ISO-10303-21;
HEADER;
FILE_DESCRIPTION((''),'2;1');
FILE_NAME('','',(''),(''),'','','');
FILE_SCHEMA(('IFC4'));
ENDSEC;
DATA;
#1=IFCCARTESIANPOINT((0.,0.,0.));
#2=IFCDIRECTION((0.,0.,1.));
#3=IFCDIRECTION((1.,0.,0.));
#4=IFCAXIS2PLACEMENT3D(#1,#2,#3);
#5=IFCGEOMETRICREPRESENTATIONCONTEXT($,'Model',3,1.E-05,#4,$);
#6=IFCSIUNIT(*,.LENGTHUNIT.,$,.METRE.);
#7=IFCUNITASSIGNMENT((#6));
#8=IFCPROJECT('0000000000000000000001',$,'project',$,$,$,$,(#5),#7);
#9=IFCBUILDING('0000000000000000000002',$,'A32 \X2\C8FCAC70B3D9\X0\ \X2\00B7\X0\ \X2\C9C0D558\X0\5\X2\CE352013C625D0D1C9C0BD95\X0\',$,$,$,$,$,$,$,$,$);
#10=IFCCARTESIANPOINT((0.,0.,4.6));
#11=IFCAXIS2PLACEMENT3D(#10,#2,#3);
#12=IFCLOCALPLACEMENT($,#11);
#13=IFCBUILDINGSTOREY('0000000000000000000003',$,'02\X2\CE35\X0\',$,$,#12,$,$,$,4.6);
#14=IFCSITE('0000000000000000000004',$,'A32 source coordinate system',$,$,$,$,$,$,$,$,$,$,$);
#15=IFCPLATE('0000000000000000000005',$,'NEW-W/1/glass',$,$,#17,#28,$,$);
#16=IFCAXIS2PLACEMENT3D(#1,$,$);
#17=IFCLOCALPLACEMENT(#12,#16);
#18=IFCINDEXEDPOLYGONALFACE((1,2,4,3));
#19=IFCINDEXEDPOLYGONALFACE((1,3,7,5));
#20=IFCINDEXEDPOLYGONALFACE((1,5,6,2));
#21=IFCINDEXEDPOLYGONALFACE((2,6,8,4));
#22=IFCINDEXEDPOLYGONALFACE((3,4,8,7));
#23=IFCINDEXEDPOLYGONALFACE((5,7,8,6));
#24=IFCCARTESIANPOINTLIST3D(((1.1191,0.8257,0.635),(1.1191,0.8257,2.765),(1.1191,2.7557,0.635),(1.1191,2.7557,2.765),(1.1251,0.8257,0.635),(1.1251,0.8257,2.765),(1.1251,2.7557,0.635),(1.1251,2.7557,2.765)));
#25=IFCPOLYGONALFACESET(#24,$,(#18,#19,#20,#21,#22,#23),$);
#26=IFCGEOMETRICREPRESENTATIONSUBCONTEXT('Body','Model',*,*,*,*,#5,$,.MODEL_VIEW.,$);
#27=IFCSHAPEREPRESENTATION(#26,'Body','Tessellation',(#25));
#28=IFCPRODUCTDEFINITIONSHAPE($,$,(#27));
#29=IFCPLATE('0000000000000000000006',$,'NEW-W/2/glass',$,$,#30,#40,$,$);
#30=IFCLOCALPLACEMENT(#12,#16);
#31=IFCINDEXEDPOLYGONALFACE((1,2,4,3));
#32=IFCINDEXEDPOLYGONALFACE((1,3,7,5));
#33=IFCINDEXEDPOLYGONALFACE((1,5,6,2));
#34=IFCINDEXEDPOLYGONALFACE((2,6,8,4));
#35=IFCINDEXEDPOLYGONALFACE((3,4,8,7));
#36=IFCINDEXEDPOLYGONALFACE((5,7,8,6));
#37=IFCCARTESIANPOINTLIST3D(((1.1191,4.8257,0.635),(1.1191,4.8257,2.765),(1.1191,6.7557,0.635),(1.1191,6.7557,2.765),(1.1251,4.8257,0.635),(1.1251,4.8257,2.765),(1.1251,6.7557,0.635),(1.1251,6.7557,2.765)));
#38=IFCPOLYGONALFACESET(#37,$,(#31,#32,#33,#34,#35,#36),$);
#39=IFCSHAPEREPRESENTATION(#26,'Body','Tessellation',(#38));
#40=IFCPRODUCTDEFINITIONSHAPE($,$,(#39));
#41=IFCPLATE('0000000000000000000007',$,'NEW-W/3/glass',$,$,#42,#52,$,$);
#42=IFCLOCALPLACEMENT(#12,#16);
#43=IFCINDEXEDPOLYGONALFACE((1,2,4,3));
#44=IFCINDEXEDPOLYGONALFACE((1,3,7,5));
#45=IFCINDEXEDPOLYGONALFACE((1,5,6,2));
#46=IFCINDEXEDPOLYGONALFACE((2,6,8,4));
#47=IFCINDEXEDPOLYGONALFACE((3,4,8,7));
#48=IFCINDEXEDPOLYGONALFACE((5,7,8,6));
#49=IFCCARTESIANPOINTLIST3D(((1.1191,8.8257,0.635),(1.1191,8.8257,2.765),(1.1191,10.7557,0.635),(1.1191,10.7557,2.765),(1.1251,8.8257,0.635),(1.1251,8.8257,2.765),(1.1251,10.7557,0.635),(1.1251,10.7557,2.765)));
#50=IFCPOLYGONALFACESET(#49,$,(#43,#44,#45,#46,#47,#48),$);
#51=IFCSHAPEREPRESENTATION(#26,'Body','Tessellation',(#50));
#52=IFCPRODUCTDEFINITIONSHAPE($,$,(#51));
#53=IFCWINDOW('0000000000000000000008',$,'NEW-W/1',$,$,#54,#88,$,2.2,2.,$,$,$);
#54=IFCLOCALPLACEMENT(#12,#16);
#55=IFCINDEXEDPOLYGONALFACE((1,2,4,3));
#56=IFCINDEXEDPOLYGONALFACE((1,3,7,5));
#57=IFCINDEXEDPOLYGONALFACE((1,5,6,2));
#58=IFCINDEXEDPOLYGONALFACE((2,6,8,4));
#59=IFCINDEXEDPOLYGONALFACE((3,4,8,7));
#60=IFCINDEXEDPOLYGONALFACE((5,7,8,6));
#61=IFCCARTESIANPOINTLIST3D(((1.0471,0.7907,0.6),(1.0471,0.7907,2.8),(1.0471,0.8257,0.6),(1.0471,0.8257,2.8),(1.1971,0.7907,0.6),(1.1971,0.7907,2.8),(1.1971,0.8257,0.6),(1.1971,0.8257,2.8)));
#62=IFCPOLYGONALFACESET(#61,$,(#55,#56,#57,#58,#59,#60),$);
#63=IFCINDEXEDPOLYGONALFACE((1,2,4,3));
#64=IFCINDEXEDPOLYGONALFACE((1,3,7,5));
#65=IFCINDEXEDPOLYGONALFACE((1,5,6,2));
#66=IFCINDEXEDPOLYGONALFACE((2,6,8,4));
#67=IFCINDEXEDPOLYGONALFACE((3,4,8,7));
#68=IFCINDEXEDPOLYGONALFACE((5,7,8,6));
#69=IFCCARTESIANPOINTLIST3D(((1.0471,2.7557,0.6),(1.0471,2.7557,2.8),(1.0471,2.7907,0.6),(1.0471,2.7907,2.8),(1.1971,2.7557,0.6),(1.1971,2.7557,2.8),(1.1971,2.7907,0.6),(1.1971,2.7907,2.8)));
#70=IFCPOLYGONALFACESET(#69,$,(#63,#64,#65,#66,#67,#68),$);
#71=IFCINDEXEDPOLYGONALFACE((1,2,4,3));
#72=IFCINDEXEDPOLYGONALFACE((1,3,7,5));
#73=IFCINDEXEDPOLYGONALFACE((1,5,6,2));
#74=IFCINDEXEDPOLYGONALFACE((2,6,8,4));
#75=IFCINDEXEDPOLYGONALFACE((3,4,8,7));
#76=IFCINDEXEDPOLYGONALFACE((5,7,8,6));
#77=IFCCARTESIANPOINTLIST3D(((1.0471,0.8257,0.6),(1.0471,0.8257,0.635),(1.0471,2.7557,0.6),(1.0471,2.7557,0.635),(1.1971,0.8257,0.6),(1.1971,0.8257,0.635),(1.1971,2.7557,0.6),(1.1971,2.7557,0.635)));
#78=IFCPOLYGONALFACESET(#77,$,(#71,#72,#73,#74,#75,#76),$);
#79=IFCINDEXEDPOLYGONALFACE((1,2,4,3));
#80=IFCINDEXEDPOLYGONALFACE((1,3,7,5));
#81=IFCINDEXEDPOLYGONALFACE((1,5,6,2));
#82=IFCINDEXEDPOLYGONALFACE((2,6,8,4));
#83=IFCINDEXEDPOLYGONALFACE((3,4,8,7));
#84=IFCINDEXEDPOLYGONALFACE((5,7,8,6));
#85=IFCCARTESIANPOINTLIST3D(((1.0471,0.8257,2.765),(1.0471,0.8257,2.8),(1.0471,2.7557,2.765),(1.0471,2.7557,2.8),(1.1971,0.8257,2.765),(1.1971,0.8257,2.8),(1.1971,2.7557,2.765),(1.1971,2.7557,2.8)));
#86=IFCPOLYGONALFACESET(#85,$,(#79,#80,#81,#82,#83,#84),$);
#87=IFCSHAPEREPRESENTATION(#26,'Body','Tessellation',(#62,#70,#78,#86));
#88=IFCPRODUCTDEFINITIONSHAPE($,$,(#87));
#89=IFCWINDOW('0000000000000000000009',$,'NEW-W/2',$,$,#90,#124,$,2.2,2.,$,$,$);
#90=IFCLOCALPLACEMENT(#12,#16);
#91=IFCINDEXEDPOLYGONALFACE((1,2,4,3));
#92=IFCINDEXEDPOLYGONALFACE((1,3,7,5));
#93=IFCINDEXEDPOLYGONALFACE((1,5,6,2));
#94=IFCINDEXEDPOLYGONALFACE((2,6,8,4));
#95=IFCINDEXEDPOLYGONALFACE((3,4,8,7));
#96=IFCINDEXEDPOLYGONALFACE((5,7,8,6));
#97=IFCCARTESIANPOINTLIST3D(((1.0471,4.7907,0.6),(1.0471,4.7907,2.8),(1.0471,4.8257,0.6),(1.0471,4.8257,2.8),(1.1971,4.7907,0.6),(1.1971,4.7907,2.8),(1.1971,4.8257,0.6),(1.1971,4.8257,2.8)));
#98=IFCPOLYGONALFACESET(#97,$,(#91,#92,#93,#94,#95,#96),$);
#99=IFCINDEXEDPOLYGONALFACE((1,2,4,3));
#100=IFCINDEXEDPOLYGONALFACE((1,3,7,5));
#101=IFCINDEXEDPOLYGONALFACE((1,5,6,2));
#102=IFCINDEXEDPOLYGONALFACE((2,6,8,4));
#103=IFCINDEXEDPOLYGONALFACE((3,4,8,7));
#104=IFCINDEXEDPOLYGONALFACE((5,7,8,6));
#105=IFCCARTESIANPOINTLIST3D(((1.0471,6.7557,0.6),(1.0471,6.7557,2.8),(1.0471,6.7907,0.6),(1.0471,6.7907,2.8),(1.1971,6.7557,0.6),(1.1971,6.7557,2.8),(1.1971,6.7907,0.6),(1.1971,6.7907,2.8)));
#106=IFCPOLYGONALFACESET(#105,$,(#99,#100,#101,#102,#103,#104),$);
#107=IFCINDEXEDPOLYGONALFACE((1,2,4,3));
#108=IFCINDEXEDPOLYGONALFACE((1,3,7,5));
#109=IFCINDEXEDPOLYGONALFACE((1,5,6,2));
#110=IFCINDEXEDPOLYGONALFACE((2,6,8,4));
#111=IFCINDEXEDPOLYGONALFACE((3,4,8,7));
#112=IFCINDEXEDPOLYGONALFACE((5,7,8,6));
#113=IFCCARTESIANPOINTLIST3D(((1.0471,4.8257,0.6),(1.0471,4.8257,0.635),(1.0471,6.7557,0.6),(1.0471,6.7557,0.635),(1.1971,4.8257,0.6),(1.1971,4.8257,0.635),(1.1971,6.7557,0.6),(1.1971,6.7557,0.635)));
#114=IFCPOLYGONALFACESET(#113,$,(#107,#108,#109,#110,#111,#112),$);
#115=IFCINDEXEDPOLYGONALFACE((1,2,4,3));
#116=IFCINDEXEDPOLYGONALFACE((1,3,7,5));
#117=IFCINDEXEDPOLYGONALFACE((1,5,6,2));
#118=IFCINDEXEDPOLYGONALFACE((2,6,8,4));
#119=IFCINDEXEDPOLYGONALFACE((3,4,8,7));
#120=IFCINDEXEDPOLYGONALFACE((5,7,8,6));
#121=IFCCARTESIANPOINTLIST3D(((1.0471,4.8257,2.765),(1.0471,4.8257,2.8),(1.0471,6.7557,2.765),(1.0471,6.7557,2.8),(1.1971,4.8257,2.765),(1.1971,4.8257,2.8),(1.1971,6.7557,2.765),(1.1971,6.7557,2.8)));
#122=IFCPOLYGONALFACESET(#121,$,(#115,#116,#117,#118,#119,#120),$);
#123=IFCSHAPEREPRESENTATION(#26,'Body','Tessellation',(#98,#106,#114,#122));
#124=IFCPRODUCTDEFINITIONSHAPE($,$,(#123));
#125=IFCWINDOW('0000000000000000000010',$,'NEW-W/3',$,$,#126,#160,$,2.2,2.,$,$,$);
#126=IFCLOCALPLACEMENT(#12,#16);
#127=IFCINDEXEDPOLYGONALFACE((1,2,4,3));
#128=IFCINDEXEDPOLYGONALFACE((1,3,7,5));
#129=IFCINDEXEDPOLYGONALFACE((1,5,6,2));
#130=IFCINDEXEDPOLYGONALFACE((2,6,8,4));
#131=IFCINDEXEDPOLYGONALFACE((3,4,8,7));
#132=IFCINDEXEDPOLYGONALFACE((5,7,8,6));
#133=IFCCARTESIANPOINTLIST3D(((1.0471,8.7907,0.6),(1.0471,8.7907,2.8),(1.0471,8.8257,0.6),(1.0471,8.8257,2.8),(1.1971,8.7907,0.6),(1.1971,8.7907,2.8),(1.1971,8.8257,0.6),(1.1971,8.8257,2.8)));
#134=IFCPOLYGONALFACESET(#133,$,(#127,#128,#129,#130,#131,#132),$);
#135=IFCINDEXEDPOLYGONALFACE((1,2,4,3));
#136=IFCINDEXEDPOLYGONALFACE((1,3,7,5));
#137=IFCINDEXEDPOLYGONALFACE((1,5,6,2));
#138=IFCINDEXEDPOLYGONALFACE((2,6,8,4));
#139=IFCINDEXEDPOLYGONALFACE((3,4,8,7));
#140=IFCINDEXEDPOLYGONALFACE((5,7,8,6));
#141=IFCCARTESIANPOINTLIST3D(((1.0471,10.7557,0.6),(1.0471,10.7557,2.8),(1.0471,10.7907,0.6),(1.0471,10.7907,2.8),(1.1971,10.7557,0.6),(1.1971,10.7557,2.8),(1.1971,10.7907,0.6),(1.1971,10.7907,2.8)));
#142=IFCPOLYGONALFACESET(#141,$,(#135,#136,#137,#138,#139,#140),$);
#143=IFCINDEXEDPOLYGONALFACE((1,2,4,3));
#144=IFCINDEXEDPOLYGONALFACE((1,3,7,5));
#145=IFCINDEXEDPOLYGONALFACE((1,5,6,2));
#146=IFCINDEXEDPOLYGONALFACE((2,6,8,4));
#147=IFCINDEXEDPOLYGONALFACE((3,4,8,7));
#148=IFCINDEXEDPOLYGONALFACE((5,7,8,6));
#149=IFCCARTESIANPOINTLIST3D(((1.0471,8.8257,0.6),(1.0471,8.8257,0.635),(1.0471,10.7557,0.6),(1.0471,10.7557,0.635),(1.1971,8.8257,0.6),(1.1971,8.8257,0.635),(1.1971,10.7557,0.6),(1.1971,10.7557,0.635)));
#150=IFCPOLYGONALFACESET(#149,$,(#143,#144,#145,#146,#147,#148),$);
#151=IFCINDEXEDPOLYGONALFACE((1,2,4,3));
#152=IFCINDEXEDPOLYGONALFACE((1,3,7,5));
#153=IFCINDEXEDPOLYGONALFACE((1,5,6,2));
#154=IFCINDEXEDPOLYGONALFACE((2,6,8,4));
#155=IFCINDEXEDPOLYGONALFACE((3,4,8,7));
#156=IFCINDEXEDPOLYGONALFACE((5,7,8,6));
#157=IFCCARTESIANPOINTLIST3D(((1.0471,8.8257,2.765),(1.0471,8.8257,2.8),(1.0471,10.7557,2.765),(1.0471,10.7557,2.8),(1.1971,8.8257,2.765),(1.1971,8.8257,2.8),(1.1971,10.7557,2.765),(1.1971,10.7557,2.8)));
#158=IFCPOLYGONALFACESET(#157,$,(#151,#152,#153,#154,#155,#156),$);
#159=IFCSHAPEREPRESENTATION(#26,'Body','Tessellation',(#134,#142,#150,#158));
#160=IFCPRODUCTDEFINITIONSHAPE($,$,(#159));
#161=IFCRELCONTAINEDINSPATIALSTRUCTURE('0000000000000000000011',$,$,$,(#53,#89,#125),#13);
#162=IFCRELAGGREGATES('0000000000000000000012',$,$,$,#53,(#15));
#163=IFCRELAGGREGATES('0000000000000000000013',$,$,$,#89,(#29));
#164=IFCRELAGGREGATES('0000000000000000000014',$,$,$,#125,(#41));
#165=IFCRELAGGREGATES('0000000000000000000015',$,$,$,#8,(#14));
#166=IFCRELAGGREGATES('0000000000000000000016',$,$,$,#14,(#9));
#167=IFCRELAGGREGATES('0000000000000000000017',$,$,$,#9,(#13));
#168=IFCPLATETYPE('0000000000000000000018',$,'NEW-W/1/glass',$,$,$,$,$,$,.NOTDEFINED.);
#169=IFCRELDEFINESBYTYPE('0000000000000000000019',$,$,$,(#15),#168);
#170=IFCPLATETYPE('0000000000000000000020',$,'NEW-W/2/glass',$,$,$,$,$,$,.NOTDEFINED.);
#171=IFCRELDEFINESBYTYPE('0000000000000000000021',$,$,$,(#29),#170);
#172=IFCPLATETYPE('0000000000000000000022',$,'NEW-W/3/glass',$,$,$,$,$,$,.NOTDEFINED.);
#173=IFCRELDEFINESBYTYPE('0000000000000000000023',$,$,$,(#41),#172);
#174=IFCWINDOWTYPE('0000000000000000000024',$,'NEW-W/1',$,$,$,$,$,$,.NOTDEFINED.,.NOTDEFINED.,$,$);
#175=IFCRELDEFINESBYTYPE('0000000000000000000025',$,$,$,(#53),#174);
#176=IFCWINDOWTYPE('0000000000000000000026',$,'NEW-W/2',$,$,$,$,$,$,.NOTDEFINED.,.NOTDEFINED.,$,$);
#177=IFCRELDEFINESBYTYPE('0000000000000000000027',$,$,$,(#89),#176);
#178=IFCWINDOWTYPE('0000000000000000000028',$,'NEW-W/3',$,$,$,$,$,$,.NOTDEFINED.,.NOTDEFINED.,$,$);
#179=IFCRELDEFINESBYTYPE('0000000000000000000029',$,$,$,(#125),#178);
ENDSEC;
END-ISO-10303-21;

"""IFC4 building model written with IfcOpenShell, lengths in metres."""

from ifc_helpers import new_model, si_unit, frame, origin, origin_with_axes, place, context, subcontext, project, spatial, polyline, outline, extrude, source, transform, mapped, type_object, type_shapes, element, aggregate, save


model = new_model("IFC4")

# Units and contexts
model_context = context("Model", 3, precision=1e-05, world=origin_with_axes())
body_context = subcontext(model_context, "Body", "Model", "MODEL_VIEW")
ifc_project = project(units=[si_unit("LENGTHUNIT", "METRE")], contexts=[model_context])

# Plates
plate_type_1 = type_object("IfcPlateType", Name="NEW-W/1/glass", PredefinedType="NOTDEFINED")
shared_shape_1 = source(origin(), body_context, "Body", "SweptSolid", [
    extrude(outline(polyline([(1.1251, 0.8257), (1.1191, 0.8257), (1.1191, 2.7557), (1.1251, 2.7557), (1.1251, 0.8257)])), frame((0.0, 0.0, 0.635)), (0.0, 0.0, 1.0), 2.13),
])
type_shapes(plate_type_1, [shared_shape_1])
storey_placement = place(None, frame((0.0, 0.0, 4.6), z_axis=(0.0, 0.0, 1.0), x_axis=(1.0, 0.0, 0.0)))
window_1_placement = place(storey_placement, origin_with_axes())
plate_1_placement = place(window_1_placement, origin_with_axes())
plate_1 = element("IfcPlate", 1, at=plate_1_placement, type_object=plate_type_1, Name="NEW-W/1/glass", context=body_context, shape_type="MappedRepresentation", body=[
    mapped(shared_shape_1, transform((0.0, 0.0, 0.0), scale=1.0)),
])
plate_type_2 = type_object("IfcPlateType", Name="NEW-W/2/glass", PredefinedType="NOTDEFINED")
shared_shape_2 = source(origin(), body_context, "Body", "SweptSolid", [
    extrude(outline(polyline([(1.1251, 4.8257), (1.1191, 4.8257), (1.1191, 6.7557), (1.1251, 6.7557), (1.1251, 4.8257)])), frame((0.0, 0.0, 0.635)), (0.0, 0.0, 1.0), 2.13),
])
type_shapes(plate_type_2, [shared_shape_2])
window_2_placement = place(storey_placement, origin_with_axes())
plate_2_placement = place(window_2_placement, origin_with_axes())
plate_2 = element("IfcPlate", 2, at=plate_2_placement, type_object=plate_type_2, Name="NEW-W/2/glass", context=body_context, shape_type="MappedRepresentation", body=[
    mapped(shared_shape_2, transform((0.0, 0.0, 0.0), scale=1.0)),
])
plate_type_3 = type_object("IfcPlateType", Name="NEW-W/3/glass", PredefinedType="NOTDEFINED")
shared_shape_3 = source(origin(), body_context, "Body", "SweptSolid", [
    extrude(outline(polyline([(1.1251, 8.8257), (1.1191, 8.8257), (1.1191, 10.7557), (1.1251, 10.7557), (1.1251, 8.8257)])), frame((0.0, 0.0, 0.635)), (0.0, 0.0, 1.0), 2.13),
])
type_shapes(plate_type_3, [shared_shape_3])
window_3_placement = place(storey_placement, origin_with_axes())
plate_3_placement = place(window_3_placement, origin_with_axes())
plate_3 = element("IfcPlate", 3, at=plate_3_placement, type_object=plate_type_3, Name="NEW-W/3/glass", context=body_context, shape_type="MappedRepresentation", body=[
    mapped(shared_shape_3, transform((0.0, 0.0, 0.0), scale=1.0)),
])

# Site, building, storey
site = spatial("IfcSite", under=ifc_project, Name="A32 source coordinate system")
building = spatial("IfcBuilding", under=site, Name="A32 주거동 · 지하5층–옥탑지붕")
storey = spatial("IfcBuildingStorey", under=building, at=storey_placement, Name="02층", Elevation=4.6)

# Windows
window_type_1 = type_object("IfcWindowType", Name="NEW-W/1", PartitioningType="NOTDEFINED", PredefinedType="NOTDEFINED")
shared_shape_4 = source(origin(), body_context, "Body", "SweptSolid", [
    extrude(outline(polyline([(1.0471, 0.7907), (1.0471, 0.8257), (1.1971, 0.8257), (1.1971, 0.7907), (1.0471, 0.7907)])), frame((0.0, 0.0, 0.6)), (0.0, 0.0, 1.0), 2.2),
    extrude(outline(polyline([(1.0471, 2.7557), (1.0471, 2.7907), (1.1971, 2.7907), (1.1971, 2.7557), (1.0471, 2.7557)])), frame((0.0, 0.0, 0.6)), (0.0, 0.0, 1.0), 2.2),
    extrude(outline(polyline([(1.1971, 0.8257), (1.1971, 2.7557), (1.0471, 2.7557), (1.0471, 0.8257), (1.1971, 0.8257)])), frame((0.0, 0.0, 0.6)), (0.0, 0.0, 1.0), 0.035),
    extrude(outline(polyline([(1.1971, 0.8257), (1.1971, 2.7557), (1.0471, 2.7557), (1.0471, 0.8257), (1.1971, 0.8257)])), frame((0.0, 0.0, 2.765)), (0.0, 0.0, 1.0), 0.035),
])
type_shapes(window_type_1, [shared_shape_4])
window_1 = element("IfcWindow", 4, at=window_1_placement, inside=storey, type_object=window_type_1, Name="NEW-W/1", OverallHeight=2.2, OverallWidth=2.0, context=body_context, shape_type="MappedRepresentation", body=[
    mapped(shared_shape_4, transform((0.0, 0.0, 0.0), scale=1.0)),
])
aggregate(window_1, [plate_1])
window_type_2 = type_object("IfcWindowType", Name="NEW-W/2", PartitioningType="NOTDEFINED", PredefinedType="NOTDEFINED")
shared_shape_5 = source(origin(), body_context, "Body", "SweptSolid", [
    extrude(outline(polyline([(1.0471, 4.7907), (1.0471, 4.8257), (1.1971, 4.8257), (1.1971, 4.7907), (1.0471, 4.7907)])), frame((0.0, 0.0, 0.6)), (0.0, 0.0, 1.0), 2.2),
    extrude(outline(polyline([(1.0471, 6.7557), (1.0471, 6.7907), (1.1971, 6.7907), (1.1971, 6.7557), (1.0471, 6.7557)])), frame((0.0, 0.0, 0.6)), (0.0, 0.0, 1.0), 2.2),
    extrude(outline(polyline([(1.1971, 4.8257), (1.1971, 6.7557), (1.0471, 6.7557), (1.0471, 4.8257), (1.1971, 4.8257)])), frame((0.0, 0.0, 0.6)), (0.0, 0.0, 1.0), 0.035),
    extrude(outline(polyline([(1.1971, 4.8257), (1.1971, 6.7557), (1.0471, 6.7557), (1.0471, 4.8257), (1.1971, 4.8257)])), frame((0.0, 0.0, 2.765)), (0.0, 0.0, 1.0), 0.035),
])
type_shapes(window_type_2, [shared_shape_5])
window_2 = element("IfcWindow", 5, at=window_2_placement, inside=storey, type_object=window_type_2, Name="NEW-W/2", OverallHeight=2.2, OverallWidth=2.0, context=body_context, shape_type="MappedRepresentation", body=[
    mapped(shared_shape_5, transform((0.0, 0.0, 0.0), scale=1.0)),
])
aggregate(window_2, [plate_2])
window_type_3 = type_object("IfcWindowType", Name="NEW-W/3", PartitioningType="NOTDEFINED", PredefinedType="NOTDEFINED")
shared_shape_6 = source(origin(), body_context, "Body", "SweptSolid", [
    extrude(outline(polyline([(1.0471, 8.7907), (1.0471, 8.8257), (1.1971, 8.8257), (1.1971, 8.7907), (1.0471, 8.7907)])), frame((0.0, 0.0, 0.6)), (0.0, 0.0, 1.0), 2.2),
    extrude(outline(polyline([(1.0471, 10.7557), (1.0471, 10.7907), (1.1971, 10.7907), (1.1971, 10.7557), (1.0471, 10.7557)])), frame((0.0, 0.0, 0.6)), (0.0, 0.0, 1.0), 2.2),
    extrude(outline(polyline([(1.1971, 8.8257), (1.1971, 10.7557), (1.0471, 10.7557), (1.0471, 8.8257), (1.1971, 8.8257)])), frame((0.0, 0.0, 0.6)), (0.0, 0.0, 1.0), 0.035),
    extrude(outline(polyline([(1.1971, 8.8257), (1.1971, 10.7557), (1.0471, 10.7557), (1.0471, 8.8257), (1.1971, 8.8257)])), frame((0.0, 0.0, 2.765)), (0.0, 0.0, 1.0), 0.035),
])
type_shapes(window_type_3, [shared_shape_6])
window_3 = element("IfcWindow", 6, at=window_3_placement, inside=storey, type_object=window_type_3, Name="NEW-W/3", OverallHeight=2.2, OverallWidth=2.0, context=body_context, shape_type="MappedRepresentation", body=[
    mapped(shared_shape_6, transform((0.0, 0.0, 0.0), scale=1.0)),
])
aggregate(window_3, [plate_3])

save(model, "model.ifc")
